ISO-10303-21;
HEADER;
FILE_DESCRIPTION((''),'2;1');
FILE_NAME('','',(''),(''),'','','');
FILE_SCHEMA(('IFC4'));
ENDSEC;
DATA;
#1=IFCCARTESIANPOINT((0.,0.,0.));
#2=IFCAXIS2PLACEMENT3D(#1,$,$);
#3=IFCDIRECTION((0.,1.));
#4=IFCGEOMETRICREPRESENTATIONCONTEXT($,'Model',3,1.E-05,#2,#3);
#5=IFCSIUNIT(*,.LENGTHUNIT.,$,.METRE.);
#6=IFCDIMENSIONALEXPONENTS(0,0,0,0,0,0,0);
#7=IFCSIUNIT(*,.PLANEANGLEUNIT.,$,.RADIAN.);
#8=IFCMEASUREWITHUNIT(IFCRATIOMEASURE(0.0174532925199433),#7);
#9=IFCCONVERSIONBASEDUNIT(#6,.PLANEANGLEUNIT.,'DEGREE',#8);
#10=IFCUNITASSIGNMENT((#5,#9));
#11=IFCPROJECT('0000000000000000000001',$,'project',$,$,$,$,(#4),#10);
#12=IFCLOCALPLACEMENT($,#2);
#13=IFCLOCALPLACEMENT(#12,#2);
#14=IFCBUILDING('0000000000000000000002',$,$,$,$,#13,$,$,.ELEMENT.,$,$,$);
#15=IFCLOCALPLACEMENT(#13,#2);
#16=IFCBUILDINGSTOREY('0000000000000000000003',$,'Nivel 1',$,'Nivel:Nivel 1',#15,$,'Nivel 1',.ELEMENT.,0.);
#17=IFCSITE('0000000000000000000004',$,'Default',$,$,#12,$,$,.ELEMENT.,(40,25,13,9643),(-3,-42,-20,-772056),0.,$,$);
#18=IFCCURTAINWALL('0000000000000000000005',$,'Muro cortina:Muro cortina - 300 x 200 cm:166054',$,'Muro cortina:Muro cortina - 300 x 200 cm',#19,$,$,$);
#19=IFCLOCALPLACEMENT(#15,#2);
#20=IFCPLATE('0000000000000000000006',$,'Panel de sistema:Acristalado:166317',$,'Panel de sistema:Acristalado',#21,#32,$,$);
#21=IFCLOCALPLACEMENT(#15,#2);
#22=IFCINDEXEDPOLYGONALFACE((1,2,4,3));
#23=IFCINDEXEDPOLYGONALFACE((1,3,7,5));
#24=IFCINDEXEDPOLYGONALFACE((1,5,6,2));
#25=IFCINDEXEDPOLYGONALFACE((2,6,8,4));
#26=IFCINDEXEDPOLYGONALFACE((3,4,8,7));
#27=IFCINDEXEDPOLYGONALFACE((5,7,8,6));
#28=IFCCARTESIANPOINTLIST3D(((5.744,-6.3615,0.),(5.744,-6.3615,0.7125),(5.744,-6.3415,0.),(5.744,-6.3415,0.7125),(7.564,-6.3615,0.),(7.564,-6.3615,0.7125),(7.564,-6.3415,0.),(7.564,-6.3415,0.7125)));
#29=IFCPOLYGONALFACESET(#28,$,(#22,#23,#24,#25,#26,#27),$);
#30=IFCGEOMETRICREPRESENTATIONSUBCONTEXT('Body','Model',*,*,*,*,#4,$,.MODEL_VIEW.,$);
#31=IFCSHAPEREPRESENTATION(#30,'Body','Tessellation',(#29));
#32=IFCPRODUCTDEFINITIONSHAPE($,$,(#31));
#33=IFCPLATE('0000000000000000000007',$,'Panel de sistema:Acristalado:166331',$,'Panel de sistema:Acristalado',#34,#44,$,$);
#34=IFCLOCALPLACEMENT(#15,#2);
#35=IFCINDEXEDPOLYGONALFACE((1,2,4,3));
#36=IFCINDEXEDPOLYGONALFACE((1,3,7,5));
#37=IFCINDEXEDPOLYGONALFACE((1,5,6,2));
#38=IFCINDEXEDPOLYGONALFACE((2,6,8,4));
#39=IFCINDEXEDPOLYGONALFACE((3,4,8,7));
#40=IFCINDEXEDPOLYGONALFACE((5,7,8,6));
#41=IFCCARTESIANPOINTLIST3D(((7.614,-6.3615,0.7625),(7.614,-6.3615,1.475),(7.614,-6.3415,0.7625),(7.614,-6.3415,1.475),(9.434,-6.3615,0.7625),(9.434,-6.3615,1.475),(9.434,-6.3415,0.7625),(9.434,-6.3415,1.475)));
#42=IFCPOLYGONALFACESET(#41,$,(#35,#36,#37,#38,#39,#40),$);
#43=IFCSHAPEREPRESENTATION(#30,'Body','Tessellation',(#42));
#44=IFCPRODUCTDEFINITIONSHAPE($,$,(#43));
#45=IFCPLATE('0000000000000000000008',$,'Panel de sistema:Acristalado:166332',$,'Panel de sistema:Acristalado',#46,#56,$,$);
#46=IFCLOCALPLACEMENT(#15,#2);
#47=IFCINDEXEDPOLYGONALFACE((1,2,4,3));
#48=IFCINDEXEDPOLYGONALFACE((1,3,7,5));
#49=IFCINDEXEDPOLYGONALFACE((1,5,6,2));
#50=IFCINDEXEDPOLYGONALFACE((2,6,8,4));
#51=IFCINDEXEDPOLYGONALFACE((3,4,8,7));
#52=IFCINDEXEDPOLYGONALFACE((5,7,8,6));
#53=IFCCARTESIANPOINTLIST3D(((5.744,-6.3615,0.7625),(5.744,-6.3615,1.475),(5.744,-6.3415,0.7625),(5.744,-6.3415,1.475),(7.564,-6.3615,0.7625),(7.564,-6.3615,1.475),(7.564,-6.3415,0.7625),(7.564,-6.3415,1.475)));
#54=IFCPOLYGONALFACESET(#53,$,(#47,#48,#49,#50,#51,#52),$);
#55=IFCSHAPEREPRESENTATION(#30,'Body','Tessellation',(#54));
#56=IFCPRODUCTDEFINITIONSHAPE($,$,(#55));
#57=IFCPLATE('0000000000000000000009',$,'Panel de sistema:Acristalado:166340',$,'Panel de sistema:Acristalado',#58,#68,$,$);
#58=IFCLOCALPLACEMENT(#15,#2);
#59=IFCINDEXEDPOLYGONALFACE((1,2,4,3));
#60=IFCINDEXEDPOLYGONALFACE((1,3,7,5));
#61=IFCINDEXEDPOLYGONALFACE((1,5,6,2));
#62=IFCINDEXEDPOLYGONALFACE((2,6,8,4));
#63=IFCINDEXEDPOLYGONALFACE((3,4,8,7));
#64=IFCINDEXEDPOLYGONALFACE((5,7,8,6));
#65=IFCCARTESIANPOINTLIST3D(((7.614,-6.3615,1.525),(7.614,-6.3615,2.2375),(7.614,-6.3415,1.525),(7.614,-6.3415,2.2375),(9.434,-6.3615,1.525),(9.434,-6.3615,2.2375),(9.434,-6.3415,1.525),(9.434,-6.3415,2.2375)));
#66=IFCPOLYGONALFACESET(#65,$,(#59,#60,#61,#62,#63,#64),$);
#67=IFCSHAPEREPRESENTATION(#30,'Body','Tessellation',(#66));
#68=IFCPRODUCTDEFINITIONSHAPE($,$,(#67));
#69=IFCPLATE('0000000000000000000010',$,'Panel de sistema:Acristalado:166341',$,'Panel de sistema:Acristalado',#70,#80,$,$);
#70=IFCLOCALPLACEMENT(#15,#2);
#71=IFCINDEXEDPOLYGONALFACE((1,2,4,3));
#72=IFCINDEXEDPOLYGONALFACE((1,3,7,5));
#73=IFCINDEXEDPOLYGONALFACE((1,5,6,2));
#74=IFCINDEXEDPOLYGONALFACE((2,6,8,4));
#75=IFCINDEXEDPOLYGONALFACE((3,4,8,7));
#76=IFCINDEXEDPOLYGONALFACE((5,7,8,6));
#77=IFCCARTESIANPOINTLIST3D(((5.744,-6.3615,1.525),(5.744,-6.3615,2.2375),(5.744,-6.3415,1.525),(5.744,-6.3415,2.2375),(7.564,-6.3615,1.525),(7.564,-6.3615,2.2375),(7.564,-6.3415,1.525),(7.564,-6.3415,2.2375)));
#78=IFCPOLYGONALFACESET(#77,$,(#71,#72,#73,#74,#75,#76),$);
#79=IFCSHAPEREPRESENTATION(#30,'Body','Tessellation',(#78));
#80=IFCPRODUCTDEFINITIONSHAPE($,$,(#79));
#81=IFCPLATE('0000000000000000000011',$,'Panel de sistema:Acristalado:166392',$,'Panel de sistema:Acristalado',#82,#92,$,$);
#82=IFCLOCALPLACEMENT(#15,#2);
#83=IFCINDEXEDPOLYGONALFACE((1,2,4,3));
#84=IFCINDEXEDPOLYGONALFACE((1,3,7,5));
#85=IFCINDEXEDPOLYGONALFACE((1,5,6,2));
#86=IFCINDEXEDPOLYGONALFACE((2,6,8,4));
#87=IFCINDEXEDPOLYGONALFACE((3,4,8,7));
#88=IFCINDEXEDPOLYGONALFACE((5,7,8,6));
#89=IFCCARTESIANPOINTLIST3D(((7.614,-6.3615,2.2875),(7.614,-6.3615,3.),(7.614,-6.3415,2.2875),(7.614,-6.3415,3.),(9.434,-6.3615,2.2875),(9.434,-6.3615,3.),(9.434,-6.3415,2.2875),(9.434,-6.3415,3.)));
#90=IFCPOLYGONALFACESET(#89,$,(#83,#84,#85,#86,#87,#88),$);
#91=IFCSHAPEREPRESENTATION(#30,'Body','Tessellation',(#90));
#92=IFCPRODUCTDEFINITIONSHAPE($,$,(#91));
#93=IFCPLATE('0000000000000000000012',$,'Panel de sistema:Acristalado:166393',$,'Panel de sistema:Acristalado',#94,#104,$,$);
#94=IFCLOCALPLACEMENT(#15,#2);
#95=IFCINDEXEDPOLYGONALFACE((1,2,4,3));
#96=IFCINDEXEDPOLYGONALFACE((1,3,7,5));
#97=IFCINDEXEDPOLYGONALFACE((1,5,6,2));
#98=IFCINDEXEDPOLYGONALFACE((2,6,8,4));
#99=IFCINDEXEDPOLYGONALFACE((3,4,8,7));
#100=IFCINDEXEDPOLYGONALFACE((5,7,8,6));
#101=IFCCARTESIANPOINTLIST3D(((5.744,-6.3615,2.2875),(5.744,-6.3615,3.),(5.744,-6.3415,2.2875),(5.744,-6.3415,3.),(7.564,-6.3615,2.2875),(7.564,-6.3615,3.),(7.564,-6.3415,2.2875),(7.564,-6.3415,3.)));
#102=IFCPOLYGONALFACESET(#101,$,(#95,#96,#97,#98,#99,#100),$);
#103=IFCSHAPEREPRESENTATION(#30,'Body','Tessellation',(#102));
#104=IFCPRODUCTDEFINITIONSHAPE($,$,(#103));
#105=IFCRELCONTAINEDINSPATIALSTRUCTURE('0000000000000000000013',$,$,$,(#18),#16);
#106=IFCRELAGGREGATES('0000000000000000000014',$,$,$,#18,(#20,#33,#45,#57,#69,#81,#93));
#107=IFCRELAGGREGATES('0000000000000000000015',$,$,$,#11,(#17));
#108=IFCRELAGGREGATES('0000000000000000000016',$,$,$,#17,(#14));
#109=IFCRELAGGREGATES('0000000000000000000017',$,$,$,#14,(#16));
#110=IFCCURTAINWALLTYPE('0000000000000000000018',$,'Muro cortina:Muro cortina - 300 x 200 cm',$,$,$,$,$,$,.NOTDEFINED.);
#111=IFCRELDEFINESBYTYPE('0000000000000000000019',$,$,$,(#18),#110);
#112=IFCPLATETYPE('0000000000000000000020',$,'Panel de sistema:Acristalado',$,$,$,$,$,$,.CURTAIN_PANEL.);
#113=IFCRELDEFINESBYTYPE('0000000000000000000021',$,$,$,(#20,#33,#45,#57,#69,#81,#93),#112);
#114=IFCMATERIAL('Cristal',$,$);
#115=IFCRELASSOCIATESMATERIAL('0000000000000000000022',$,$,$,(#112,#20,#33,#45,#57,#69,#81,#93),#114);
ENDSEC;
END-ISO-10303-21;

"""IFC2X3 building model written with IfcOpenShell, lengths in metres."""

from ifc_helpers import new_model, entity, si_unit, converted_unit, direction, frame, origin, origin_2d_with_axis, place, context, subcontext, project, spatial, rectangle, extrude, source, transform, mapped, material, type_object, type_shapes, element, aggregate, save


model = new_model("IFC2X3")

# Units and contexts
model_context = context("Model", 3, precision=1e-05, world=origin(), true_north=direction((0.0, 1.0)))
body_context = subcontext(model_context, "Body", "Model", "MODEL_VIEW")
ifc_project = project(units=[si_unit("LENGTHUNIT", "METRE"), converted_unit("PLANEANGLEUNIT", "DEGREE", entity("IfcRatioMeasure", 0.0174532925199433), si_unit("PLANEANGLEUNIT", "RADIAN"), dimensions=[0, 0, 0, 0, 0, 0, 0])], contexts=[model_context])

# Site, building, storey
site_placement = place(None, origin())
site = spatial("IfcSite", under=ifc_project, at=site_placement, Name="Default", CompositionType="ELEMENT", RefLatitude=(40, 25, 13, 9643), RefLongitude=(-3, -42, -20, -772056), RefElevation=0.0)
building_placement = place(site_placement, origin())
building = spatial("IfcBuilding", under=site, at=building_placement, CompositionType="ELEMENT")
storey_placement = place(building_placement, origin())
storey = spatial("IfcBuildingStorey", under=building, at=storey_placement, Name="Nivel 1", ObjectType="Nivel:Nivel 1", LongName="Nivel 1", CompositionType="ELEMENT", Elevation=0.0)

# Curtain wall
curtain_wall_type = type_object("IfcCurtainWallType", Name="Muro cortina:Muro cortina - 300 x 200 cm", PredefinedType="NOTDEFINED")
curtain_wall_1_placement = place(storey_placement, origin())
curtain_wall_1 = element("IfcCurtainWall", 1, at=curtain_wall_1_placement, inside=storey, type_object=curtain_wall_type, Name="Muro cortina:Muro cortina - 300 x 200 cm:166054", ObjectType="Muro cortina:Muro cortina - 300 x 200 cm")

# Plates
ifc_material_1 = material(Name="Cristal")
plate_type = type_object("IfcPlateType", Name="Panel de sistema:Acristalado", PredefinedType="CURTAIN_PANEL", material=ifc_material_1)
shared_shape_1 = source(origin(), body_context, "Body", "SweptSolid", [
    extrude(rectangle(XDim=0.02, YDim=1.82, at=origin_2d_with_axis()), frame((0.0, 0.0, 0.0), z_axis=(0.0, 0.0, 1.0), x_axis=(0.0, 1.0, 0.0)), (0.0, 0.0, 1.0), 0.7125),
])
type_shapes(plate_type, [shared_shape_1])
plate_1_placement = place(curtain_wall_1_placement, frame((6.654, -6.3515, 0.0), z_axis=(0.0, 0.0, 1.0), x_axis=(-1.0, 0.0, 0.0)))
plate_1 = element("IfcPlate", 2, at=plate_1_placement, type_object=plate_type, material=ifc_material_1, Name="Panel de sistema:Acristalado:166317", ObjectType="Panel de sistema:Acristalado", context=body_context, shape_type="MappedRepresentation", body=[
    mapped(shared_shape_1, transform((0.0, 0.0, 0.0), scale=1.0)),
])
plate_2_placement = place(curtain_wall_1_placement, frame((8.524, -6.3515, 0.7625), z_axis=(0.0, 0.0, 1.0), x_axis=(-1.0, 0.0, 0.0)))
plate_2 = element("IfcPlate", 3, at=plate_2_placement, type_object=plate_type, material=ifc_material_1, Name="Panel de sistema:Acristalado:166331", ObjectType="Panel de sistema:Acristalado", context=body_context, shape_type="MappedRepresentation", body=[
    mapped(shared_shape_1, transform((0.0, 0.0, 0.0), scale=1.0)),
])
plate_3_placement = place(curtain_wall_1_placement, frame((6.654, -6.3515, 0.7625), z_axis=(0.0, 0.0, 1.0), x_axis=(-1.0, 0.0, 0.0)))
plate_3 = element("IfcPlate", 4, at=plate_3_placement, type_object=plate_type, material=ifc_material_1, Name="Panel de sistema:Acristalado:166332", ObjectType="Panel de sistema:Acristalado", context=body_context, shape_type="MappedRepresentation", body=[
    mapped(shared_shape_1, transform((0.0, 0.0, 0.0), scale=1.0)),
])
plate_4_placement = place(curtain_wall_1_placement, frame((8.524, -6.3515, 1.525), z_axis=(0.0, 0.0, 1.0), x_axis=(-1.0, 0.0, 0.0)))
plate_4 = element("IfcPlate", 5, at=plate_4_placement, type_object=plate_type, material=ifc_material_1, Name="Panel de sistema:Acristalado:166340", ObjectType="Panel de sistema:Acristalado", context=body_context, shape_type="MappedRepresentation", body=[
    mapped(shared_shape_1, transform((0.0, 0.0, 0.0), scale=1.0)),
])
plate_5_placement = place(curtain_wall_1_placement, frame((6.654, -6.3515, 1.525), z_axis=(0.0, 0.0, 1.0), x_axis=(-1.0, 0.0, 0.0)))
plate_5 = element("IfcPlate", 6, at=plate_5_placement, type_object=plate_type, material=ifc_material_1, Name="Panel de sistema:Acristalado:166341", ObjectType="Panel de sistema:Acristalado", context=body_context, shape_type="MappedRepresentation", body=[
    mapped(shared_shape_1, transform((0.0, 0.0, 0.0), scale=1.0)),
])
plate_6_placement = place(curtain_wall_1_placement, frame((8.524, -6.3515, 2.2875), z_axis=(0.0, 0.0, 1.0), x_axis=(-1.0, 0.0, 0.0)))
plate_6 = element("IfcPlate", 7, at=plate_6_placement, type_object=plate_type, material=ifc_material_1, Name="Panel de sistema:Acristalado:166392", ObjectType="Panel de sistema:Acristalado", context=body_context, shape_type="MappedRepresentation", body=[
    mapped(shared_shape_1, transform((0.0, 0.0, 0.0), scale=1.0)),
])
plate_7_placement = place(curtain_wall_1_placement, frame((6.654, -6.3515, 2.2875), z_axis=(0.0, 0.0, 1.0), x_axis=(-1.0, 0.0, 0.0)))
plate_7 = element("IfcPlate", 8, at=plate_7_placement, type_object=plate_type, material=ifc_material_1, Name="Panel de sistema:Acristalado:166393", ObjectType="Panel de sistema:Acristalado", context=body_context, shape_type="MappedRepresentation", body=[
    mapped(shared_shape_1, transform((0.0, 0.0, 0.0), scale=1.0)),
])
aggregate(curtain_wall_1, [plate_1, plate_2, plate_3, plate_4, plate_5, plate_6, plate_7])

save(model, "model.ifc")
